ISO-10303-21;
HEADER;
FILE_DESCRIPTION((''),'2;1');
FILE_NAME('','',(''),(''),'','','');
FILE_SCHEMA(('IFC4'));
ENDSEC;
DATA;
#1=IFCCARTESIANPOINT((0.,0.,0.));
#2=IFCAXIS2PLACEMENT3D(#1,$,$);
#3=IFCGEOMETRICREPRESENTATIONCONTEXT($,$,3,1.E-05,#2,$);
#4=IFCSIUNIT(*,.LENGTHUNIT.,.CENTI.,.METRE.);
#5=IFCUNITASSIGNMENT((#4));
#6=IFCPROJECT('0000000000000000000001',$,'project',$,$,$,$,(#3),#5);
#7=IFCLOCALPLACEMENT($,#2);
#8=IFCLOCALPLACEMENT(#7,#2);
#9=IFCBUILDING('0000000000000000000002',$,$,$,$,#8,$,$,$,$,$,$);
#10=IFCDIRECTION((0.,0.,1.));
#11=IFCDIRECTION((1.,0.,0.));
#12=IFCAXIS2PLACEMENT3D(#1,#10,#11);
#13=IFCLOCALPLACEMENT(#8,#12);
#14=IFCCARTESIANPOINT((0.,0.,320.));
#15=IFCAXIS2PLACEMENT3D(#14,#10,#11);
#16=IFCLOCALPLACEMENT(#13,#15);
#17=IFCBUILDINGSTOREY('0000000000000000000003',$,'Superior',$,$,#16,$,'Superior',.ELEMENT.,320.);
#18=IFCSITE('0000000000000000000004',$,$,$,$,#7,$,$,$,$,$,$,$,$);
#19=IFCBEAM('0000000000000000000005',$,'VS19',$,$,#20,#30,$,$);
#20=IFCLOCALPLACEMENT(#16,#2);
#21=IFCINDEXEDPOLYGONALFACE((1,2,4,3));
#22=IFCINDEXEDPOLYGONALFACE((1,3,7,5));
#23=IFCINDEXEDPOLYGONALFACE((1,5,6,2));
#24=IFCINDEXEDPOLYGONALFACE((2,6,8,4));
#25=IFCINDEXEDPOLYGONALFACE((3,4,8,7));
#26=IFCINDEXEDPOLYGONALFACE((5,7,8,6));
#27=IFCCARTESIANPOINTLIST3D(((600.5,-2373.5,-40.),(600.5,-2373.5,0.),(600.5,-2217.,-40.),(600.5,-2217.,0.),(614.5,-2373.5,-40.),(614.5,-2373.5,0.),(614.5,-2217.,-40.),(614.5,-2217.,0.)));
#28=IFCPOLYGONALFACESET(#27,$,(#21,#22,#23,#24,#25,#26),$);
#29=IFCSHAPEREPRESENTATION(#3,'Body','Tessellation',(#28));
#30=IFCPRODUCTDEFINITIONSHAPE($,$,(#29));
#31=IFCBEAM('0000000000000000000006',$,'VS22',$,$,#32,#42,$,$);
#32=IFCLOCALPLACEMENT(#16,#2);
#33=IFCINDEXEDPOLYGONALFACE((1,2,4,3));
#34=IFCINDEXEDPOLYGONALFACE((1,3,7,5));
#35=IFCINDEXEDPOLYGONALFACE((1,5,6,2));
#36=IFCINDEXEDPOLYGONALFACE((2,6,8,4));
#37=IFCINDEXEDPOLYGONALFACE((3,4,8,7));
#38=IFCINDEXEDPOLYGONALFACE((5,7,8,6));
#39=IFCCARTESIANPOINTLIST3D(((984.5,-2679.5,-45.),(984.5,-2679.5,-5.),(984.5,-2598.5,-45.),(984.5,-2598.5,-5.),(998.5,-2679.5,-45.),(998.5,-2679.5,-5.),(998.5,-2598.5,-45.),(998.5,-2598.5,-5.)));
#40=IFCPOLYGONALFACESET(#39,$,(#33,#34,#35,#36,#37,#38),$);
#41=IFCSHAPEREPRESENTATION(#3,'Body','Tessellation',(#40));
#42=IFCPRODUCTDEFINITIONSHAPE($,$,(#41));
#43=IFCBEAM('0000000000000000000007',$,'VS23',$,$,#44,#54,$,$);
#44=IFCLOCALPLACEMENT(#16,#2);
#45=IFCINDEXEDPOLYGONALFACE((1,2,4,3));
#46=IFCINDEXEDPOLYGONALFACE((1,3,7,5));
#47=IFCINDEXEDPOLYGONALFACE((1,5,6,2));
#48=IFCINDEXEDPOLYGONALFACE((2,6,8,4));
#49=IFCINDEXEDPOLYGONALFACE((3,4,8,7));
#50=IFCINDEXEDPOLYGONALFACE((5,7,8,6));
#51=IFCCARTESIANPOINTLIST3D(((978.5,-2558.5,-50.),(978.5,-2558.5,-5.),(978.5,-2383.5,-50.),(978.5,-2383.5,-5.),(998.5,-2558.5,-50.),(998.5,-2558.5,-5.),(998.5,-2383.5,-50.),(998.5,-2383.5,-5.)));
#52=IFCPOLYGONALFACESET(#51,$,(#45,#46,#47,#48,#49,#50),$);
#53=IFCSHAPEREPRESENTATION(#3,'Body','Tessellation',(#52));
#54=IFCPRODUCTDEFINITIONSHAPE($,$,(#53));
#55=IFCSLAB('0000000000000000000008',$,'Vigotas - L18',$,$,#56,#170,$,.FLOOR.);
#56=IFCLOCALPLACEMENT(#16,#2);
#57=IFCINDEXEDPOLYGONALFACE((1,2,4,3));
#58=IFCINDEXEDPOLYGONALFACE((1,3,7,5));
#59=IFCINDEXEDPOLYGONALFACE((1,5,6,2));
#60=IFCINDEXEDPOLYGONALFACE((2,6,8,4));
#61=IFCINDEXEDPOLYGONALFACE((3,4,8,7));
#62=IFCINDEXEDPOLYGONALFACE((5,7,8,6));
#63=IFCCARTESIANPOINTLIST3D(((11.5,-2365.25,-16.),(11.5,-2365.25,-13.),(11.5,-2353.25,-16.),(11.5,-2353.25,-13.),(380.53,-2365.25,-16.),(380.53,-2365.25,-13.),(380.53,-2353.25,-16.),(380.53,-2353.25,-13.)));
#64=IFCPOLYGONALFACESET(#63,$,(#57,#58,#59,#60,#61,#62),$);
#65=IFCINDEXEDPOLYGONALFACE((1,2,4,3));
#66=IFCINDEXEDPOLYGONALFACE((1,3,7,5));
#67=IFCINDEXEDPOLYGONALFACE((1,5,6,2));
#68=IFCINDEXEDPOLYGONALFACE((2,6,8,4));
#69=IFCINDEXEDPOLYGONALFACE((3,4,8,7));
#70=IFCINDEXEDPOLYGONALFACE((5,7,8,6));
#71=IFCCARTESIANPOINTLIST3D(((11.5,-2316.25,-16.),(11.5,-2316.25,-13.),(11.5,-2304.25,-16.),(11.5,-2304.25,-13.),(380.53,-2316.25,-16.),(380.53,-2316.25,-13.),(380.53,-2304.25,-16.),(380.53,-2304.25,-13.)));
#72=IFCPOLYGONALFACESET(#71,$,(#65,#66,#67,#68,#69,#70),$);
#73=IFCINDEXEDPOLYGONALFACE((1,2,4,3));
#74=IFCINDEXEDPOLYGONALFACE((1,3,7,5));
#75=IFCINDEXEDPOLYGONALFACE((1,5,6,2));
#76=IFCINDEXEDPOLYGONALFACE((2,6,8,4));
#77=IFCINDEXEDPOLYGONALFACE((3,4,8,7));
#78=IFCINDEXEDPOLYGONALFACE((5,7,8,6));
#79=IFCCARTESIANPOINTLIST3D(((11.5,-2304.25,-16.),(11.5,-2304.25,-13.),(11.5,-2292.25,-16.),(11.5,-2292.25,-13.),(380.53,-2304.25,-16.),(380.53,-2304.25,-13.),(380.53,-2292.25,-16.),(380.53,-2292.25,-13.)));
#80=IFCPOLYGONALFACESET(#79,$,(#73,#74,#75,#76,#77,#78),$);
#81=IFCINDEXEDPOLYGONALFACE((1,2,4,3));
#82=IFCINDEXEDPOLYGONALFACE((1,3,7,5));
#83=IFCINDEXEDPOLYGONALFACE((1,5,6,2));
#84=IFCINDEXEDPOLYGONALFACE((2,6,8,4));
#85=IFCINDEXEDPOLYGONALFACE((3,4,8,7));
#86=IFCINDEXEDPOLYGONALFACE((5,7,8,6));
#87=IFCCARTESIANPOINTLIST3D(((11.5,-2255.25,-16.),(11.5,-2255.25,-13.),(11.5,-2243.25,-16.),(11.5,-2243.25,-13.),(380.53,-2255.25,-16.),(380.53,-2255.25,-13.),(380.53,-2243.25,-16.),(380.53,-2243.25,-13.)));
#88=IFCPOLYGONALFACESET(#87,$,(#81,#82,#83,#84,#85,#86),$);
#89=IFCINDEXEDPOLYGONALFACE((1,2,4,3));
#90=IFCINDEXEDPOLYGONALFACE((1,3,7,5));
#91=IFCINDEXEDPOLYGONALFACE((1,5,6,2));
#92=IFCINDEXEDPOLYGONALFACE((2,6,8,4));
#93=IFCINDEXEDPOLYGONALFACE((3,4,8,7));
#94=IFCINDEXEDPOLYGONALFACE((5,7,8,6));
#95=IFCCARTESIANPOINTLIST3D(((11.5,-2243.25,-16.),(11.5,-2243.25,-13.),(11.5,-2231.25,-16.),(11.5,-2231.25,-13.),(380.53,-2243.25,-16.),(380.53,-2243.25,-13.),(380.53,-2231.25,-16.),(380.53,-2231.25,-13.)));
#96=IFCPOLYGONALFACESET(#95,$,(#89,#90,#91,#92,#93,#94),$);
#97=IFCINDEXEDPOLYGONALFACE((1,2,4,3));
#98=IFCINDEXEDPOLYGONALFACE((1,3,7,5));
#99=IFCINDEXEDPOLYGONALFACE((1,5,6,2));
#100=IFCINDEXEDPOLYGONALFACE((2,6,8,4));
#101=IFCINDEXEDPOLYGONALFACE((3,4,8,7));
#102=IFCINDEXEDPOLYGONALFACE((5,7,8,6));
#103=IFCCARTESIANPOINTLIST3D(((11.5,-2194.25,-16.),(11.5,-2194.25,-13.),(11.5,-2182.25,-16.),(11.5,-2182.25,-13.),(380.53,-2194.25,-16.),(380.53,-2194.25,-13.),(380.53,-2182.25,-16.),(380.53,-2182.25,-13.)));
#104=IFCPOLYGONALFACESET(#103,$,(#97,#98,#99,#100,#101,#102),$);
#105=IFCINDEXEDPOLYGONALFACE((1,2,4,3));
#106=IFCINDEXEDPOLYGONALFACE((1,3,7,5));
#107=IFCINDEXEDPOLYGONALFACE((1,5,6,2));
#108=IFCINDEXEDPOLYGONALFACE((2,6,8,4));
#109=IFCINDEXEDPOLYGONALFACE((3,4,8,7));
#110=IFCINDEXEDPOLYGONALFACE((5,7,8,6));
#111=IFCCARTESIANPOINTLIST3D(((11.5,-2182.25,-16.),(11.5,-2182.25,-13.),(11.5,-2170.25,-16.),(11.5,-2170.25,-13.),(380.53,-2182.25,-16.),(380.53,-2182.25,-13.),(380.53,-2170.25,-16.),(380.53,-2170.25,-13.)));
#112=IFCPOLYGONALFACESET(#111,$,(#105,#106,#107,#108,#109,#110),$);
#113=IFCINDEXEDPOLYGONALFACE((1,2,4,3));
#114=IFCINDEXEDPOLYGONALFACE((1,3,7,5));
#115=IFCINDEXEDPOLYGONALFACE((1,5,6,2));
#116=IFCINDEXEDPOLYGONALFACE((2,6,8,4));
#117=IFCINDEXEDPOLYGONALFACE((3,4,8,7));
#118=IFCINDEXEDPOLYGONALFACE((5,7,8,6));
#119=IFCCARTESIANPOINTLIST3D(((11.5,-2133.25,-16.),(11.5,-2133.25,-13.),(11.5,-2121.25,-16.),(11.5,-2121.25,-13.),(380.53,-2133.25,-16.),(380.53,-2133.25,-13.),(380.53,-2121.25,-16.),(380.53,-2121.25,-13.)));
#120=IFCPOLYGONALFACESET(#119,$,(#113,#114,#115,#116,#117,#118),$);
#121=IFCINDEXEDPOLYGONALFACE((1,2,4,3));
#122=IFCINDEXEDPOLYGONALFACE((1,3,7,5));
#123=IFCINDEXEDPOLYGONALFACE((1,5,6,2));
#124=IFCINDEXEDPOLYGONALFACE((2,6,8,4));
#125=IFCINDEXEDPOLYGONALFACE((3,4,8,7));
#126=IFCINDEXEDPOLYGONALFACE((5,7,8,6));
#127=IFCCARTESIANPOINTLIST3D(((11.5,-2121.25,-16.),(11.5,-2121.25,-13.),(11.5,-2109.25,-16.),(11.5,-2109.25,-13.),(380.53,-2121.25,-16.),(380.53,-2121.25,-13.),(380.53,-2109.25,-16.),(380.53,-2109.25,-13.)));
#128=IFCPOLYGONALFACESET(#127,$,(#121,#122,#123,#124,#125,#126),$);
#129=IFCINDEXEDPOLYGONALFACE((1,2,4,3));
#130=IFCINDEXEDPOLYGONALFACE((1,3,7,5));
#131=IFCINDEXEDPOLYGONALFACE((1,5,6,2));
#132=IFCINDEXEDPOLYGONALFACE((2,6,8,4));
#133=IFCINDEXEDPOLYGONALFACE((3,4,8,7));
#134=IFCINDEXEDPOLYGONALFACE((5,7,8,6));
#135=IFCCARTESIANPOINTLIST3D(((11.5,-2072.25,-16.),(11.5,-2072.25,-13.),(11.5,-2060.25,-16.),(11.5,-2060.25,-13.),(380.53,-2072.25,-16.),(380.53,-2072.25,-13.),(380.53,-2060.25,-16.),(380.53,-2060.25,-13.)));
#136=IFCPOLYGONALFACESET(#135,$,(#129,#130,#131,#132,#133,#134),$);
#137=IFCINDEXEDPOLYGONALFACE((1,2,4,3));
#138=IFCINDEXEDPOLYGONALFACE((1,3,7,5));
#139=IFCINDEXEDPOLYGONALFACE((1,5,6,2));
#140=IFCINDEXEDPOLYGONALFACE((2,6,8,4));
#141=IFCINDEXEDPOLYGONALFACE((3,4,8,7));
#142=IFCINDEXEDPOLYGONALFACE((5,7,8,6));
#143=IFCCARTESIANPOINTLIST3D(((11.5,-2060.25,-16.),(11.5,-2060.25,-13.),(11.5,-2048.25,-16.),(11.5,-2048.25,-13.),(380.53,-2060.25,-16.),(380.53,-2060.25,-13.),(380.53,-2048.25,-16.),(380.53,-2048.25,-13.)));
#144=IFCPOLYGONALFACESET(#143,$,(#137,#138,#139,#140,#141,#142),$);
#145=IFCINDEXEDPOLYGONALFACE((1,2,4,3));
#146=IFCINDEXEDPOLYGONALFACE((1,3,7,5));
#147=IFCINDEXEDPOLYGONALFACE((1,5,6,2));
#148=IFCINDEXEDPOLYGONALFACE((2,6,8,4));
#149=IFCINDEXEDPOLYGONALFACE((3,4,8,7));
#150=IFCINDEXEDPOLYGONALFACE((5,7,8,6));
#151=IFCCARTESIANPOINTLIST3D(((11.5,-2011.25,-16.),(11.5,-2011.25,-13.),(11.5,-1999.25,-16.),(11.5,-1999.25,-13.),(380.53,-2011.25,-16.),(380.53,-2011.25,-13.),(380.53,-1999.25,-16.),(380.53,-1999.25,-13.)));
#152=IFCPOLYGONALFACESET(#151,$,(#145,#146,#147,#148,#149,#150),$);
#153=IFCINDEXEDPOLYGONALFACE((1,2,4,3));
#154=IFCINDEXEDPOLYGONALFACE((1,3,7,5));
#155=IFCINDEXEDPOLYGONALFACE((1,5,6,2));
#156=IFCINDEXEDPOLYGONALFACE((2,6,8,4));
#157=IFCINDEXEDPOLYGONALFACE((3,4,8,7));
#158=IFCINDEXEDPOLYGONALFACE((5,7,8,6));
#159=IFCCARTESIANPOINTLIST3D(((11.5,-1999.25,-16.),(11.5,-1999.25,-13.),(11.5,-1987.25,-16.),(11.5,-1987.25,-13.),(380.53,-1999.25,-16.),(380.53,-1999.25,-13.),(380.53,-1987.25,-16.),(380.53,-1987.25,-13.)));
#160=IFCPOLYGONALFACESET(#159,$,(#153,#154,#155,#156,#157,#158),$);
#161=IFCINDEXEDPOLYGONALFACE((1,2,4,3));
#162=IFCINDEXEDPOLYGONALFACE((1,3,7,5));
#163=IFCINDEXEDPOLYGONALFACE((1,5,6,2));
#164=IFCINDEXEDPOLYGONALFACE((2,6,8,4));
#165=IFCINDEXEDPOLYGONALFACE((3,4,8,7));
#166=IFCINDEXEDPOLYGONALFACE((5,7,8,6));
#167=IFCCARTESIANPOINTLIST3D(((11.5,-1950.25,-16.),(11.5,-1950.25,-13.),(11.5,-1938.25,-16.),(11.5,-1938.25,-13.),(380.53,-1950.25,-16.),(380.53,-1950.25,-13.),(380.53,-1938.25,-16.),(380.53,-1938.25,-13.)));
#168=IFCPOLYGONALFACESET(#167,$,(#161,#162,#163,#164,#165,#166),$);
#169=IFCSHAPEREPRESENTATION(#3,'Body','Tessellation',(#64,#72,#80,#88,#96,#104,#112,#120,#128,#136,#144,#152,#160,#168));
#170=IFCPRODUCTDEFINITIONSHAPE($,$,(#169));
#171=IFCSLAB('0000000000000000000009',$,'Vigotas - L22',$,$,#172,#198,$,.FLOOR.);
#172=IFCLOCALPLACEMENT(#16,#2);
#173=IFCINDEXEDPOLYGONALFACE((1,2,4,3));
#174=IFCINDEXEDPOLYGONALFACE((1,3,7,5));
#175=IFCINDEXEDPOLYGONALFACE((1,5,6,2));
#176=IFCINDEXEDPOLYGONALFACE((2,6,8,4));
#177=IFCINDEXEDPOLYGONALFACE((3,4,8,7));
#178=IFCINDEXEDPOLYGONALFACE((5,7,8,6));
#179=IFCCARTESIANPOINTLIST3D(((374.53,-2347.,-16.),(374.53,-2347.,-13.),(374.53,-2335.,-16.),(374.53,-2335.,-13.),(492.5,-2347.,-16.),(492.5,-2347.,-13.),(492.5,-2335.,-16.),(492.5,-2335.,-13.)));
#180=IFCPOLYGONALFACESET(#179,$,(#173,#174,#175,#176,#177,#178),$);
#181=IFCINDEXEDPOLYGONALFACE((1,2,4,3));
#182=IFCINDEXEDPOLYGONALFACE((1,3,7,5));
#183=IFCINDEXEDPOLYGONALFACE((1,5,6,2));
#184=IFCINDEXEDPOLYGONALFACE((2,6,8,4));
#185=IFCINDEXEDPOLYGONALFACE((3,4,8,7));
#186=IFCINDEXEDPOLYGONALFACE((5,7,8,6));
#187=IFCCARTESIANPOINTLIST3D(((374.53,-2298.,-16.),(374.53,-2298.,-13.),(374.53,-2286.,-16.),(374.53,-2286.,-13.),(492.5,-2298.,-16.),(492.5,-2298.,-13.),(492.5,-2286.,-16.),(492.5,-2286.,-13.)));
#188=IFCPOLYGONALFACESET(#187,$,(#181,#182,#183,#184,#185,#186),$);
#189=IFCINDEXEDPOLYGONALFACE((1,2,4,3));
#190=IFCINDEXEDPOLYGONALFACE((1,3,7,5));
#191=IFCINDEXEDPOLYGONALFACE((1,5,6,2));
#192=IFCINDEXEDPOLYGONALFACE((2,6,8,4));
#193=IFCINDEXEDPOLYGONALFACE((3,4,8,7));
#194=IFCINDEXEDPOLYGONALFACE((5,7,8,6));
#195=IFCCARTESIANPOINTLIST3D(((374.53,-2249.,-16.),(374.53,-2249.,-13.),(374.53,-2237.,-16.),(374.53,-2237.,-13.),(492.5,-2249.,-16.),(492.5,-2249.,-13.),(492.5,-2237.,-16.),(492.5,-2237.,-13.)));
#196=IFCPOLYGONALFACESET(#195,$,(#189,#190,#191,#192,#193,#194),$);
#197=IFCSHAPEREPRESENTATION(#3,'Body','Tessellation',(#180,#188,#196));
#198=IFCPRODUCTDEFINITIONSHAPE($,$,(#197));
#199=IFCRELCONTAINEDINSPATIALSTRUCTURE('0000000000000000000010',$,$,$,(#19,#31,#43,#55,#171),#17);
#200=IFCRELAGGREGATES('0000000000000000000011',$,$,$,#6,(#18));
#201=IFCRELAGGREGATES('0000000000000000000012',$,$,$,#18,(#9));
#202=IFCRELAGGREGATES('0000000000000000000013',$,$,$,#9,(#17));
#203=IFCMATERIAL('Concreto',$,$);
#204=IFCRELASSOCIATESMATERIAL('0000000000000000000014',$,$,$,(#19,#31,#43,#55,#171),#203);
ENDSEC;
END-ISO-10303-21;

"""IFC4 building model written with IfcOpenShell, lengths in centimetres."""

from ifc_helpers import new_model, si_unit, frame, origin, origin_with_axes, place, context, project, spatial, polyline, outline, extrude, material, element, save


model = new_model("IFC4")

# Units and contexts
context_of_model = context(None, 3, precision=1e-05, world=origin())
ifc_project = project(units=[si_unit("LENGTHUNIT", "METRE", prefix="CENTI")], contexts=[context_of_model])

# Site, building, storey
site_placement = place(None, origin())
site = spatial("IfcSite", under=ifc_project, at=site_placement)
building_placement = place(site_placement, origin())
building = spatial("IfcBuilding", under=site, at=building_placement)
placement = place(building_placement, origin_with_axes())
storey_placement = place(placement, frame((0.0, 0.0, 320.0), z_axis=(0.0, 0.0, 1.0), x_axis=(1.0, 0.0, 0.0)))
storey = spatial("IfcBuildingStorey", under=building, at=storey_placement, Name="Superior", LongName="Superior", CompositionType="ELEMENT", Elevation=320.0)

# Shared definitions
ifc_material = material(Name="Concreto")

# Beams
beam_1_placement = place(storey_placement, frame((607.5, -2295.25, 0.0), z_axis=(0.0, 0.0, 1.0), x_axis=(1.0, 0.0, 0.0)))
element("IfcBeam", 1, at=beam_1_placement, inside=storey, material=ifc_material, Name="VS19", context=context_of_model, shape_type="SolidModel", body=[
    extrude(outline(polyline([(-7.0, -20.0), (7.0, -20.0), (7.0, 20.0), (-7.0, 20.0), (-7.0, -20.0)])), frame((0.0, -78.25, -20.0), z_axis=(0.0, 1.0, 0.0), x_axis=(1.0, 0.0, 0.0)), (0.0, 0.0, 1.0), 156.5),
])
beam_2_placement = place(storey_placement, frame((991.5, -2639.0, -5.0), z_axis=(0.0, 0.0, 1.0), x_axis=(1.0, 0.0, 0.0)))
element("IfcBeam", 2, at=beam_2_placement, inside=storey, material=ifc_material, Name="VS22", context=context_of_model, shape_type="SolidModel", body=[
    extrude(outline(polyline([(-7.0, -20.0), (7.0, -20.0), (7.0, 20.0), (-7.0, 20.0), (-7.0, -20.0)])), frame((0.0, -40.5, -20.0), z_axis=(0.0, 1.0, 0.0), x_axis=(1.0, 0.0, 0.0)), (0.0, 0.0, 1.0), 81.0),
])
beam_3_placement = place(storey_placement, frame((988.5, -2471.0, -5.0), z_axis=(0.0, 0.0, 1.0), x_axis=(1.0, 0.0, 0.0)))
element("IfcBeam", 3, at=beam_3_placement, inside=storey, material=ifc_material, Name="VS23", context=context_of_model, shape_type="SolidModel", body=[
    extrude(outline(polyline([(-10.0, -22.5), (10.0, -22.5), (10.0, 22.5), (-10.0, 22.5), (-10.0, -22.5)])), frame((0.0, -87.5, -22.5), z_axis=(0.0, 1.0, 0.0), x_axis=(1.0, 0.0, 0.0)), (0.0, 0.0, 1.0), 175.0),
])

# Slabs
slab_1_placement = place(storey_placement, frame((196.01, -2151.75, -13.0), z_axis=(0.0, 0.0, 1.0), x_axis=(1.0, 0.0, 0.0)))
element("IfcSlab", 4, at=slab_1_placement, inside=storey, material=ifc_material, Name="Vigotas - L18", PredefinedType="FLOOR", context=context_of_model, shape_type="SolidModel", body=[
    extrude(outline(polyline([(6.0, 1.5), (-6.0, 1.5), (-6.0, -1.5), (6.0, -1.5), (6.0, 1.5), (6.0, 1.5)])), frame((-184.51, -207.5, -1.5), z_axis=(1.0, 0.0, 0.0), x_axis=(0.0, -1.0, 0.0)), (0.0, 0.0, 1.0), 369.03),
    extrude(outline(polyline([(6.0, 1.5), (-6.0, 1.5), (-6.0, -1.5), (6.0, -1.5), (6.0, 1.5), (6.0, 1.5)])), frame((-184.51, -158.5, -1.5), z_axis=(1.0, 0.0, 0.0), x_axis=(0.0, -1.0, 0.0)), (0.0, 0.0, 1.0), 369.03),
    extrude(outline(polyline([(6.0, 1.5), (-6.0, 1.5), (-6.0, -1.5), (6.0, -1.5), (6.0, 1.5), (6.0, 1.5)])), frame((-184.51, -146.5, -1.5), z_axis=(1.0, 0.0, 0.0), x_axis=(0.0, -1.0, 0.0)), (0.0, 0.0, 1.0), 369.03),
    extrude(outline(polyline([(6.0, 1.5), (-6.0, 1.5), (-6.0, -1.5), (6.0, -1.5), (6.0, 1.5), (6.0, 1.5)])), frame((-184.51, -97.5, -1.5), z_axis=(1.0, 0.0, 0.0), x_axis=(0.0, -1.0, 0.0)), (0.0, 0.0, 1.0), 369.03),
    extrude(outline(polyline([(6.0, 1.5), (-6.0, 1.5), (-6.0, -1.5), (6.0, -1.5), (6.0, 1.5), (6.0, 1.5)])), frame((-184.51, -85.5, -1.5), z_axis=(1.0, 0.0, 0.0), x_axis=(0.0, -1.0, 0.0)), (0.0, 0.0, 1.0), 369.03),
    extrude(outline(polyline([(6.0, 1.5), (-6.0, 1.5), (-6.0, -1.5), (6.0, -1.5), (6.0, 1.5), (6.0, 1.5)])), frame((-184.51, -36.5, -1.5), z_axis=(1.0, 0.0, 0.0), x_axis=(0.0, -1.0, 0.0)), (0.0, 0.0, 1.0), 369.03),
    extrude(outline(polyline([(6.0, 1.5), (-6.0, 1.5), (-6.0, -1.5), (6.0, -1.5), (6.0, 1.5), (6.0, 1.5)])), frame((-184.51, -24.5, -1.5), z_axis=(1.0, 0.0, 0.0), x_axis=(0.0, -1.0, 0.0)), (0.0, 0.0, 1.0), 369.03),
    extrude(outline(polyline([(6.0, 1.5), (-6.0, 1.5), (-6.0, -1.5), (6.0, -1.5), (6.0, 1.5), (6.0, 1.5)])), frame((-184.51, 24.5, -1.5), z_axis=(1.0, 0.0, 0.0), x_axis=(0.0, -1.0, 0.0)), (0.0, 0.0, 1.0), 369.03),
    extrude(outline(polyline([(6.0, 1.5), (-6.0, 1.5), (-6.0, -1.5), (6.0, -1.5), (6.0, 1.5), (6.0, 1.5)])), frame((-184.51, 36.5, -1.5), z_axis=(1.0, 0.0, 0.0), x_axis=(0.0, -1.0, 0.0)), (0.0, 0.0, 1.0), 369.03),
    extrude(outline(polyline([(6.0, 1.5), (-6.0, 1.5), (-6.0, -1.5), (6.0, -1.5), (6.0, 1.5), (6.0, 1.5)])), frame((-184.51, 85.5, -1.5), z_axis=(1.0, 0.0, 0.0), x_axis=(0.0, -1.0, 0.0)), (0.0, 0.0, 1.0), 369.03),
    extrude(outline(polyline([(6.0, 1.5), (-6.0, 1.5), (-6.0, -1.5), (6.0, -1.5), (6.0, 1.5), (6.0, 1.5)])), frame((-184.51, 97.5, -1.5), z_axis=(1.0, 0.0, 0.0), x_axis=(0.0, -1.0, 0.0)), (0.0, 0.0, 1.0), 369.03),
    extrude(outline(polyline([(6.0, 1.5), (-6.0, 1.5), (-6.0, -1.5), (6.0, -1.5), (6.0, 1.5), (6.0, 1.5)])), frame((-184.51, 146.5, -1.5), z_axis=(1.0, 0.0, 0.0), x_axis=(0.0, -1.0, 0.0)), (0.0, 0.0, 1.0), 369.03),
    extrude(outline(polyline([(6.0, 1.5), (-6.0, 1.5), (-6.0, -1.5), (6.0, -1.5), (6.0, 1.5), (6.0, 1.5)])), frame((-184.51, 158.5, -1.5), z_axis=(1.0, 0.0, 0.0), x_axis=(0.0, -1.0, 0.0)), (0.0, 0.0, 1.0), 369.03),
    extrude(outline(polyline([(6.0, 1.5), (-6.0, 1.5), (-6.0, -1.5), (6.0, -1.5), (6.0, 1.5), (6.0, 1.5)])), frame((-184.51, 207.5, -1.5), z_axis=(1.0, 0.0, 0.0), x_axis=(0.0, -1.0, 0.0)), (0.0, 0.0, 1.0), 369.03),
])
slab_2_placement = place(storey_placement, frame((433.51, -2292.0, -13.0), z_axis=(0.0, 0.0, 1.0), x_axis=(1.0, 0.0, 0.0)))
element("IfcSlab", 5, at=slab_2_placement, inside=storey, material=ifc_material, Name="Vigotas - L22", PredefinedType="FLOOR", context=context_of_model, shape_type="SolidModel", body=[
    extrude(outline(polyline([(6.0, 1.5), (-6.0, 1.5), (-6.0, -1.5), (6.0, -1.5), (6.0, 1.5), (6.0, 1.5)])), frame((-58.98, -49.0, -1.5), z_axis=(1.0, 0.0, 0.0), x_axis=(0.0, -1.0, 0.0)), (0.0, 0.0, 1.0), 117.97),
    extrude(outline(polyline([(6.0, 1.5), (-6.0, 1.5), (-6.0, -1.5), (6.0, -1.5), (6.0, 1.5), (6.0, 1.5)])), frame((-58.98, 0.0, -1.5), z_axis=(1.0, 0.0, 0.0), x_axis=(0.0, -1.0, 0.0)), (0.0, 0.0, 1.0), 117.97),
    extrude(outline(polyline([(6.0, 1.5), (-6.0, 1.5), (-6.0, -1.5), (6.0, -1.5), (6.0, 1.5), (6.0, 1.5)])), frame((-58.98, 49.0, -1.5), z_axis=(1.0, 0.0, 0.0), x_axis=(0.0, -1.0, 0.0)), (0.0, 0.0, 1.0), 117.97),
])

save(model, "model.ifc")
